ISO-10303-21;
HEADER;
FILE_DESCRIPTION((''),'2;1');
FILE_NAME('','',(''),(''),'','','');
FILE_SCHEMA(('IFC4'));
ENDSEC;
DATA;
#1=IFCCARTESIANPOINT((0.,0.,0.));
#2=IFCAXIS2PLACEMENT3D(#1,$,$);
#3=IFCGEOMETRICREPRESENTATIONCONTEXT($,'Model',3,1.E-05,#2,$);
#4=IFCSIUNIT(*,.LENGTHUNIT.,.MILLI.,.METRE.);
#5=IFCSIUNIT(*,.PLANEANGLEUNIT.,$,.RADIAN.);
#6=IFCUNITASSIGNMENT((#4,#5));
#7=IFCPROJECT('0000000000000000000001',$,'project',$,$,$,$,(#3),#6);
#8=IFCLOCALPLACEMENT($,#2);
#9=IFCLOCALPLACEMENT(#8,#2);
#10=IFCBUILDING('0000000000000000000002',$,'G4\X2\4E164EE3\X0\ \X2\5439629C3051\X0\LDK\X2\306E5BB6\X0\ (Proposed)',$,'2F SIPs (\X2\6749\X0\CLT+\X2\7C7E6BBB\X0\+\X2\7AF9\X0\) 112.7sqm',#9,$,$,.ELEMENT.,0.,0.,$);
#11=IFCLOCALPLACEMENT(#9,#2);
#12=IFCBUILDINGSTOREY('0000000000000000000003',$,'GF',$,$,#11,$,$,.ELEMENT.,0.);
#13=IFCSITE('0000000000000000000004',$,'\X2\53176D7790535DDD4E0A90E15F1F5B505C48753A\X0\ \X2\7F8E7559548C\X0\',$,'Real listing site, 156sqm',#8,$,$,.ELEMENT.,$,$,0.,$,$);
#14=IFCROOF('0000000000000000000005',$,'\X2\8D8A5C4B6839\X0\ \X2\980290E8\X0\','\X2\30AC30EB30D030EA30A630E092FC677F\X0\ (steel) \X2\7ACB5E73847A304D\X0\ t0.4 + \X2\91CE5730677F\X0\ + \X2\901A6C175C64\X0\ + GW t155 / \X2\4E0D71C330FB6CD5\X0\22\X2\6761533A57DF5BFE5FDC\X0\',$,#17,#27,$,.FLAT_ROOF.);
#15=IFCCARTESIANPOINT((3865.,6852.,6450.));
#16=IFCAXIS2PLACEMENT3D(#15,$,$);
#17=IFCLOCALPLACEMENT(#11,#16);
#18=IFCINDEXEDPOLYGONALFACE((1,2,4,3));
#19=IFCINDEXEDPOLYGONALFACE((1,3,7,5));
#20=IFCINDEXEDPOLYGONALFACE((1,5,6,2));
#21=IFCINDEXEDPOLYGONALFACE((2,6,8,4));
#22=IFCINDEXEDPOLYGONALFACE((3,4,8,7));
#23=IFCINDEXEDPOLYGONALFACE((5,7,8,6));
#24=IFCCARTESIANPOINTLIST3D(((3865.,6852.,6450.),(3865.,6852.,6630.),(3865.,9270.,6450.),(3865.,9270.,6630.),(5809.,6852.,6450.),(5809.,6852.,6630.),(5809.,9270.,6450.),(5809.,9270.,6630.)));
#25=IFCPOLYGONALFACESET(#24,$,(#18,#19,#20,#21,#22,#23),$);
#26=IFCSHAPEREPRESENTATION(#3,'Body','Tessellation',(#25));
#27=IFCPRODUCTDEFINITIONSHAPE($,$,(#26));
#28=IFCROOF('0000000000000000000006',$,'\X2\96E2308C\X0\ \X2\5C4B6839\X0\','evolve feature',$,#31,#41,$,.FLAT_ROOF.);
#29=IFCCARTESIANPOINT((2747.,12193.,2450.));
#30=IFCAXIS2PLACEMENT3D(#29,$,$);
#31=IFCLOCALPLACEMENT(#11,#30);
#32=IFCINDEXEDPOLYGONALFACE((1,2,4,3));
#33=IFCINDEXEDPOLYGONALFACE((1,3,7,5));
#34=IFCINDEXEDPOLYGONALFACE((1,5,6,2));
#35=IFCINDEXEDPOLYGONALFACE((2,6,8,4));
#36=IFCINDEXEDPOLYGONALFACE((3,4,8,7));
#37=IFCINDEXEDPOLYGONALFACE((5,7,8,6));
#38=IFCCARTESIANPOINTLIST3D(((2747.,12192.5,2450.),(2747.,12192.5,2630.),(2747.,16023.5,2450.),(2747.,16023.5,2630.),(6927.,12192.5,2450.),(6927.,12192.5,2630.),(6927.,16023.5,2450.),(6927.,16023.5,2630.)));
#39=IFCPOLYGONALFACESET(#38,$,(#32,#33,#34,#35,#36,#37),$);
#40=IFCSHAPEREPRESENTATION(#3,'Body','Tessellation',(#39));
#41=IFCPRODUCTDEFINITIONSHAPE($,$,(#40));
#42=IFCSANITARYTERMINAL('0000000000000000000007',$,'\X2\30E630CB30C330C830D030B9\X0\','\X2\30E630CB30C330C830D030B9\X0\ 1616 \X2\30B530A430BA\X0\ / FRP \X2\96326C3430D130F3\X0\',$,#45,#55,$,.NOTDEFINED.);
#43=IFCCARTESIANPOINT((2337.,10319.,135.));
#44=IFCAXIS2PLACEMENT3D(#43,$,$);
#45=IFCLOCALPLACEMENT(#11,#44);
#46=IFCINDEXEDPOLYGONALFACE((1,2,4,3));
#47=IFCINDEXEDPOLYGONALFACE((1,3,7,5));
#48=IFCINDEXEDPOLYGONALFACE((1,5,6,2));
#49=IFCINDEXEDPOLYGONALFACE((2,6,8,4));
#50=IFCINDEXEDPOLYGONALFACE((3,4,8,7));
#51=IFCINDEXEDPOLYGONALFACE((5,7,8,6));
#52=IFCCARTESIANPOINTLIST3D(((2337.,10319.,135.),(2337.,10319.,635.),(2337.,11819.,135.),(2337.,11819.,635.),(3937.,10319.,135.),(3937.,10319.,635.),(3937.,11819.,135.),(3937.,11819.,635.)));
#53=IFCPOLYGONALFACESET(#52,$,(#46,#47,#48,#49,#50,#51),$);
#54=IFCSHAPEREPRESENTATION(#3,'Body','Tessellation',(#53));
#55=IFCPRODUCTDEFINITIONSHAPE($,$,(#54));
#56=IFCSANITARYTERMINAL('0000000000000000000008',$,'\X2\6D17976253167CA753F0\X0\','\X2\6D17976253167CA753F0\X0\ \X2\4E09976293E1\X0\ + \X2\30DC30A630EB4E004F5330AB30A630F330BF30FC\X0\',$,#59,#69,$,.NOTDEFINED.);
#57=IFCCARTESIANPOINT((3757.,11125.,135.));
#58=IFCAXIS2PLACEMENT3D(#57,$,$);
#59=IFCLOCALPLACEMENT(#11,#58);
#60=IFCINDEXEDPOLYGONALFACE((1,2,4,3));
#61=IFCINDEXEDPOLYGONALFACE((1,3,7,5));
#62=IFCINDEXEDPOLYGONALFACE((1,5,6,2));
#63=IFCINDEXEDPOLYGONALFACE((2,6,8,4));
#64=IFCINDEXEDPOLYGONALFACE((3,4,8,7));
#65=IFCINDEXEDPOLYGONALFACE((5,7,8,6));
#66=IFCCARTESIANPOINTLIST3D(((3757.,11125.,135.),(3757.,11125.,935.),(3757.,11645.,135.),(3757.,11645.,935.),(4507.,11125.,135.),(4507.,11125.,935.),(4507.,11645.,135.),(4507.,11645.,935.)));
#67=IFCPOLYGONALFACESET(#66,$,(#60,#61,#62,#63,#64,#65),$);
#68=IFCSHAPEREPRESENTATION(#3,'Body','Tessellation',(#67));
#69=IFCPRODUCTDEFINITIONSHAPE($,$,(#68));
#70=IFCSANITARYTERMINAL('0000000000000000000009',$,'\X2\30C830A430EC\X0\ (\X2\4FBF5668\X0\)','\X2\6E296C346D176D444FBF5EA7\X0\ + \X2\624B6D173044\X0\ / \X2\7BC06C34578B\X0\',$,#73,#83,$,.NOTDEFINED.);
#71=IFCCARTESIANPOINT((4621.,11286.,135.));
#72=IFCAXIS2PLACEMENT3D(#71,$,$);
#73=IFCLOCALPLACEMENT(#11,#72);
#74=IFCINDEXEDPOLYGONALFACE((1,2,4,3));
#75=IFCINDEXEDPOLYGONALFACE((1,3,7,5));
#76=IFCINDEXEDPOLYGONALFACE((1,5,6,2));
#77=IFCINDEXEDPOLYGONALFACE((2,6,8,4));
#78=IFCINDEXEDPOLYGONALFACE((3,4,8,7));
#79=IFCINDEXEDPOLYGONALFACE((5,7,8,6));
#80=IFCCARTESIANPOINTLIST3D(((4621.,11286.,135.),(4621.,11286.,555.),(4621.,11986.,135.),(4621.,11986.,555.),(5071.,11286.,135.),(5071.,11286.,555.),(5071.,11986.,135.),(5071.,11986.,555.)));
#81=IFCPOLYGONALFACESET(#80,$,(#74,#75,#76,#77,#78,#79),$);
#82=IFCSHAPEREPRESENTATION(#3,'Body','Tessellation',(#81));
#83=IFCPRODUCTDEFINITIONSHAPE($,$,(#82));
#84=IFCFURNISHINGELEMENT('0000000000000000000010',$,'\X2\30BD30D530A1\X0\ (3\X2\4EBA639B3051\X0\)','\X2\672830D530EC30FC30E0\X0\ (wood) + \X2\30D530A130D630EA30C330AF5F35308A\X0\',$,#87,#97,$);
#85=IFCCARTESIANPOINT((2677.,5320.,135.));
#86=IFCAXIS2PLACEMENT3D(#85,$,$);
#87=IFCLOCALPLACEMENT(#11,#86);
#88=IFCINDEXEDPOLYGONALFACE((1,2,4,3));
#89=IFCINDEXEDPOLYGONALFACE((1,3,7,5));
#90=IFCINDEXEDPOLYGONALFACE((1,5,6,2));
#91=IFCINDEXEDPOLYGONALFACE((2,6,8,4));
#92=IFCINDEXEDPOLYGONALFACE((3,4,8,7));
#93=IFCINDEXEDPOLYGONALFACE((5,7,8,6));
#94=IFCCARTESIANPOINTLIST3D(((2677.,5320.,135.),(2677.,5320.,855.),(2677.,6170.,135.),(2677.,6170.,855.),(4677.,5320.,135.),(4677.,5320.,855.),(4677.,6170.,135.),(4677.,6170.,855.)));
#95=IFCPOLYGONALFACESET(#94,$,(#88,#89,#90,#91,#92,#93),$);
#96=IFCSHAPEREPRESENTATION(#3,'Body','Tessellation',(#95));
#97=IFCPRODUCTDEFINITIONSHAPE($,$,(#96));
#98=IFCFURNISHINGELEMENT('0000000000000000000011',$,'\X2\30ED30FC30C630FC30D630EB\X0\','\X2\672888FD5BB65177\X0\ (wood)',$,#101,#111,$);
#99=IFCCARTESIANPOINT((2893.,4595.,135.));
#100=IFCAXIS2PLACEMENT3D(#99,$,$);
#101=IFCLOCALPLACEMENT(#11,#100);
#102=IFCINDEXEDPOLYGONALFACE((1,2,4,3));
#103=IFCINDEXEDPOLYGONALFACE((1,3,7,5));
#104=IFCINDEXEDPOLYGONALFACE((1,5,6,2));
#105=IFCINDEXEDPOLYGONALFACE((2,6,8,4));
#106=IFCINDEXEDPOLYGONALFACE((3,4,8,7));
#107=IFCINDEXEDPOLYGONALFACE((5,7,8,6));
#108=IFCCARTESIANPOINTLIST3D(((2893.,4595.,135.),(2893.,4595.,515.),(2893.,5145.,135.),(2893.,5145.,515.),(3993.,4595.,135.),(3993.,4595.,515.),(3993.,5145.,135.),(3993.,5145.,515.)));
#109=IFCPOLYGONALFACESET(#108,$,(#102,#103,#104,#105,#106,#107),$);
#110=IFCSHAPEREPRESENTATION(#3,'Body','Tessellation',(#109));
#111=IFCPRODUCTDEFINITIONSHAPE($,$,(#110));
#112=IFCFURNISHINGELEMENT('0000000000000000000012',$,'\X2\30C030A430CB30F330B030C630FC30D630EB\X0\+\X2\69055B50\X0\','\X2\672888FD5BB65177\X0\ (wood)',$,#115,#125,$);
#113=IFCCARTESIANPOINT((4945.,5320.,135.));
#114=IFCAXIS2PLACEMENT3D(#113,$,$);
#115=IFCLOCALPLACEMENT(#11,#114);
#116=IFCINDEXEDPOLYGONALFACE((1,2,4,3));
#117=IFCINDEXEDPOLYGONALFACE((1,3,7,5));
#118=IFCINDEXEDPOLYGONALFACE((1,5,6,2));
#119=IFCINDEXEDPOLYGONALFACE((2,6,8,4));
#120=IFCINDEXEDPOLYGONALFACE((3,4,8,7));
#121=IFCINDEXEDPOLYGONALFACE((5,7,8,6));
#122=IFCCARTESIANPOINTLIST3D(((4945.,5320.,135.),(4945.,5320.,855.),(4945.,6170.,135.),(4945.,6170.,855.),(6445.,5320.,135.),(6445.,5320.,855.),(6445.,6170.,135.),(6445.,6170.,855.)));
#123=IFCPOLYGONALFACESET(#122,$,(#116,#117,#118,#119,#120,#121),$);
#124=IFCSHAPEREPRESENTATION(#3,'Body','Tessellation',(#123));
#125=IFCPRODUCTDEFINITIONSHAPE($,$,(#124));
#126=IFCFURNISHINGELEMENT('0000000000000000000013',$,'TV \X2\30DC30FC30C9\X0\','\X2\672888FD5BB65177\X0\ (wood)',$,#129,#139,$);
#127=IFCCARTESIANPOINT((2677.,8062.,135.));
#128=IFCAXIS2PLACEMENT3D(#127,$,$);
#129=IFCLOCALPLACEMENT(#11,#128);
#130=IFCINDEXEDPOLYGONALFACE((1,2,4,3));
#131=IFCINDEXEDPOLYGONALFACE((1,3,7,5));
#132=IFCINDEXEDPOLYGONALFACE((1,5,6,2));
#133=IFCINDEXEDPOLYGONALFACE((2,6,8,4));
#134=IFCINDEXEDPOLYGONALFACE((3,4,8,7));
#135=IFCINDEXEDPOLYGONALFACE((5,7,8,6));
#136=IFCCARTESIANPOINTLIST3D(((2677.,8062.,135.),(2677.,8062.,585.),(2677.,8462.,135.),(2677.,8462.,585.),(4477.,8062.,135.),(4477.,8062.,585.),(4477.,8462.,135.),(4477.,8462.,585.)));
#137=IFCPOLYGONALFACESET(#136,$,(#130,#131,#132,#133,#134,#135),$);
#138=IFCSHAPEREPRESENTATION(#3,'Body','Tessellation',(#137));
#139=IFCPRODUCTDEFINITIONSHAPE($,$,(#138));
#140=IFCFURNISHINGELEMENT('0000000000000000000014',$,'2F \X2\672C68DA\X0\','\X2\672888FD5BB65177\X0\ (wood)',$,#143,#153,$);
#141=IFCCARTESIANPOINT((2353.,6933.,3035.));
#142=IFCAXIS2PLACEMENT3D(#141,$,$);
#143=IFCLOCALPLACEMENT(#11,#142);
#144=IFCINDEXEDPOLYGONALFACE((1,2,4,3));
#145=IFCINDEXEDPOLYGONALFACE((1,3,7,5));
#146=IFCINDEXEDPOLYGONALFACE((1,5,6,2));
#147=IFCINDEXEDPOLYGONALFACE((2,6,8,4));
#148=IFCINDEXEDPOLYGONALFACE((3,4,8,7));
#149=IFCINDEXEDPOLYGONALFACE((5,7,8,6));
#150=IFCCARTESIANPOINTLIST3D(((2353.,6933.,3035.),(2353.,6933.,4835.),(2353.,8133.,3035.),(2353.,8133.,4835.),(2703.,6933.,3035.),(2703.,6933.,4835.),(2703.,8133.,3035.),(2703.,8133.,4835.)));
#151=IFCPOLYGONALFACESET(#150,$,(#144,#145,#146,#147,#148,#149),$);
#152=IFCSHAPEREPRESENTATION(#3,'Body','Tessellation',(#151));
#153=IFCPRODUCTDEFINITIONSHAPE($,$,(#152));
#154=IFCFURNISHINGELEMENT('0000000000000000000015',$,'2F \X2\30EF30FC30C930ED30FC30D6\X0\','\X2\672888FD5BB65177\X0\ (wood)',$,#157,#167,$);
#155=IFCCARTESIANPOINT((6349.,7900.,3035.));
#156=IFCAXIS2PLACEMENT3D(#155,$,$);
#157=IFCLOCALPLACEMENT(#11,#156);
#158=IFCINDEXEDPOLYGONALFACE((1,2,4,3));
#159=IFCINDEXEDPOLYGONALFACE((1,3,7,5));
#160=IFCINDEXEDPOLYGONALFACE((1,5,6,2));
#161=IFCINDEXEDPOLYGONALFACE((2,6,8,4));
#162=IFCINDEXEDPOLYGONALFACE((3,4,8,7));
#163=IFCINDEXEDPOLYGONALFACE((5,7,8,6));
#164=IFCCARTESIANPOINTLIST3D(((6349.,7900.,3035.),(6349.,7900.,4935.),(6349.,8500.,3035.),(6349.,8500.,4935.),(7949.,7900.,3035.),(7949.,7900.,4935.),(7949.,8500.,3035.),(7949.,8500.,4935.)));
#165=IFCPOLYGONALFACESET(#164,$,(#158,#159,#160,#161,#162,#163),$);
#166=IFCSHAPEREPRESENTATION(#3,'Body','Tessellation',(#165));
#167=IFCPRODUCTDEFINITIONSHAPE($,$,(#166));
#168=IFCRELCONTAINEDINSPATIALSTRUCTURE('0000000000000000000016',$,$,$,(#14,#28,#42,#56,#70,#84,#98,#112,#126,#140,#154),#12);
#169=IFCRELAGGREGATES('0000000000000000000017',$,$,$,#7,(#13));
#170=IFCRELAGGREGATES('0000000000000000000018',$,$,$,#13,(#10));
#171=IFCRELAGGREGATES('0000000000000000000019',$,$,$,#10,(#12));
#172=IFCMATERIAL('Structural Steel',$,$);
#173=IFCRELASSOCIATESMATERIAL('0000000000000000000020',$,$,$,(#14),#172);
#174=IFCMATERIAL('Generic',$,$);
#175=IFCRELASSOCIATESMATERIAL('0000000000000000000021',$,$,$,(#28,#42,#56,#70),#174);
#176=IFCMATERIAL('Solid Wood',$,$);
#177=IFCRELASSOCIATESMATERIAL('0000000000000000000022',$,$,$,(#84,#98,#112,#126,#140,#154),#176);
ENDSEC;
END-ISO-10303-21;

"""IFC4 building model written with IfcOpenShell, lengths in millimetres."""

from ifc_helpers import new_model, si_unit, frame, frame_2d, origin, place, context, project, spatial, rectangle, extrude, material, element, save


model = new_model("IFC4")

# Units and contexts
model_context = context("Model", 3, precision=1e-05, world=origin())
ifc_project = project(units=[si_unit("LENGTHUNIT", "METRE", prefix="MILLI"), si_unit("PLANEANGLEUNIT", "RADIAN")], contexts=[model_context])

# Site, building, storey
site_placement = place(None, origin())
site = spatial("IfcSite", under=ifc_project, at=site_placement, Name="北海道川上郡弟子屈町 美留和", ObjectType="Real listing site, 156sqm", CompositionType="ELEMENT", RefElevation=0.0)
building_placement = place(site_placement, origin())
building = spatial("IfcBuilding", under=site, at=building_placement, Name="G4世代 吹抜けLDKの家 (Proposed)", ObjectType="2F SIPs (杉CLT+籾殻+竹) 112.7sqm", CompositionType="ELEMENT", ElevationOfRefHeight=0.0, ElevationOfTerrain=0.0)
storey_placement = place(building_placement, origin())
storey = spatial("IfcBuildingStorey", under=building, at=storey_placement, Name="GF", CompositionType="ELEMENT", Elevation=0.0)

# Shared definitions
ifc_material_1 = material(Name="Generic")

# Shared definitions
ifc_material_2 = material(Name="Solid Wood")

# Roofs
ifc_material_3 = material(Name="Structural Steel")
roof_1_placement = place(storey_placement, frame((3865.0, 6852.0, 6450.0)))
element("IfcRoof", 1, at=roof_1_placement, inside=storey, material=ifc_material_3, Name="越屋根 頂部", Description="ガルバリウム鋼板 (steel) 立平葺き t0.4 + 野地板 + 通気層 + GW t155 / 不燃・法22条区域対応", PredefinedType="FLAT_ROOF", context=model_context, shape_type="SweptSolid", body=[
    extrude(rectangle(XDim=1944.0, YDim=2418.0, at=frame_2d((972.0, 1209.0))), frame((3865.0, 6852.0, 6450.0)), (0.0, 0.0, 1.0), 180.0),
])
roof_2_placement = place(storey_placement, frame((2747.0, 12193.0, 2450.0)))
element("IfcRoof", 2, at=roof_2_placement, inside=storey, material=ifc_material_1, Name="離れ 屋根", Description="evolve feature", PredefinedType="FLAT_ROOF", context=model_context, shape_type="SweptSolid", body=[
    extrude(rectangle(XDim=4180.0, YDim=3831.0, at=frame_2d((2090.0, 1915.0))), frame((2747.0, 12193.0, 2450.0)), (0.0, 0.0, 1.0), 180.0),
])

# Sanitary terminals
sanitary_terminal_1_placement = place(storey_placement, frame((2337.0, 10319.0, 135.0)))
element("IfcSanitaryTerminal", 3, at=sanitary_terminal_1_placement, inside=storey, material=ifc_material_1, Name="ユニットバス", Description="ユニットバス 1616 サイズ / FRP 防水パン", PredefinedType="NOTDEFINED", context=model_context, shape_type="SweptSolid", body=[
    extrude(rectangle(XDim=1600.0, YDim=1500.0, at=frame_2d((800.0, 750.0))), frame((2337.0, 10319.0, 135.0)), (0.0, 0.0, 1.0), 500.0),
])
sanitary_terminal_2_placement = place(storey_placement, frame((3757.0, 11125.0, 135.0)))
element("IfcSanitaryTerminal", 4, at=sanitary_terminal_2_placement, inside=storey, material=ifc_material_1, Name="洗面化粧台", Description="洗面化粧台 三面鏡 + ボウル一体カウンター", PredefinedType="NOTDEFINED", context=model_context, shape_type="SweptSolid", body=[
    extrude(rectangle(XDim=750.0, YDim=520.0, at=frame_2d((375.0, 260.0))), frame((3757.0, 11125.0, 135.0)), (0.0, 0.0, 1.0), 800.0),
])
sanitary_terminal_3_placement = place(storey_placement, frame((4621.0, 11286.0, 135.0)))
element("IfcSanitaryTerminal", 5, at=sanitary_terminal_3_placement, inside=storey, material=ifc_material_1, Name="トイレ (便器)", Description="温水洗浄便座 + 手洗い / 節水型", PredefinedType="NOTDEFINED", context=model_context, shape_type="SweptSolid", body=[
    extrude(rectangle(XDim=450.0, YDim=700.0, at=frame_2d((225.0, 350.0))), frame((4621.0, 11286.0, 135.0)), (0.0, 0.0, 1.0), 420.0),
])

# Furnishing elements
furnishing_1_placement = place(storey_placement, frame((2677.0, 5320.0, 135.0)))
element("IfcFurnishingElement", 6, at=furnishing_1_placement, inside=storey, material=ifc_material_2, Name="ソファ (3人掛け)", Description="木フレーム (wood) + ファブリック張り", context=model_context, shape_type="SweptSolid", body=[
    extrude(rectangle(XDim=2000.0, YDim=850.0, at=frame_2d((1000.0, 425.0))), frame((2677.0, 5320.0, 135.0)), (0.0, 0.0, 1.0), 720.0),
])
furnishing_2_placement = place(storey_placement, frame((2893.0, 4595.0, 135.0)))
element("IfcFurnishingElement", 7, at=furnishing_2_placement, inside=storey, material=ifc_material_2, Name="ローテーブル", Description="木製家具 (wood)", context=model_context, shape_type="SweptSolid", body=[
    extrude(rectangle(XDim=1100.0, YDim=550.0, at=frame_2d((550.0, 275.0))), frame((2893.0, 4595.0, 135.0)), (0.0, 0.0, 1.0), 380.0),
])
furnishing_3_placement = place(storey_placement, frame((4945.0, 5320.0, 135.0)))
element("IfcFurnishingElement", 8, at=furnishing_3_placement, inside=storey, material=ifc_material_2, Name="ダイニングテーブル+椅子", Description="木製家具 (wood)", context=model_context, shape_type="SweptSolid", body=[
    extrude(rectangle(XDim=1500.0, YDim=850.0, at=frame_2d((750.0, 425.0))), frame((4945.0, 5320.0, 135.0)), (0.0, 0.0, 1.0), 720.0),
])
furnishing_4_placement = place(storey_placement, frame((2677.0, 8062.0, 135.0)))
element("IfcFurnishingElement", 9, at=furnishing_4_placement, inside=storey, material=ifc_material_2, Name="TV ボード", Description="木製家具 (wood)", context=model_context, shape_type="SweptSolid", body=[
    extrude(rectangle(XDim=1800.0, YDim=400.0, at=frame_2d((900.0, 200.0))), frame((2677.0, 8062.0, 135.0)), (0.0, 0.0, 1.0), 450.0),
])
furnishing_5_placement = place(storey_placement, frame((2353.0, 6933.0, 3035.0)))
element("IfcFurnishingElement", 10, at=furnishing_5_placement, inside=storey, material=ifc_material_2, Name="2F 本棚", Description="木製家具 (wood)", context=model_context, shape_type="SweptSolid", body=[
    extrude(rectangle(XDim=350.0, YDim=1200.0, at=frame_2d((175.0, 600.0))), frame((2353.0, 6933.0, 3035.0)), (0.0, 0.0, 1.0), 1800.0),
])
furnishing_6_placement = place(storey_placement, frame((6349.0, 7900.0, 3035.0)))
element("IfcFurnishingElement", 11, at=furnishing_6_placement, inside=storey, material=ifc_material_2, Name="2F ワードローブ", Description="木製家具 (wood)", context=model_context, shape_type="SweptSolid", body=[
    extrude(rectangle(XDim=1600.0, YDim=600.0, at=frame_2d((800.0, 300.0))), frame((6349.0, 7900.0, 3035.0)), (0.0, 0.0, 1.0), 1900.0),
])

save(model, "model.ifc")
